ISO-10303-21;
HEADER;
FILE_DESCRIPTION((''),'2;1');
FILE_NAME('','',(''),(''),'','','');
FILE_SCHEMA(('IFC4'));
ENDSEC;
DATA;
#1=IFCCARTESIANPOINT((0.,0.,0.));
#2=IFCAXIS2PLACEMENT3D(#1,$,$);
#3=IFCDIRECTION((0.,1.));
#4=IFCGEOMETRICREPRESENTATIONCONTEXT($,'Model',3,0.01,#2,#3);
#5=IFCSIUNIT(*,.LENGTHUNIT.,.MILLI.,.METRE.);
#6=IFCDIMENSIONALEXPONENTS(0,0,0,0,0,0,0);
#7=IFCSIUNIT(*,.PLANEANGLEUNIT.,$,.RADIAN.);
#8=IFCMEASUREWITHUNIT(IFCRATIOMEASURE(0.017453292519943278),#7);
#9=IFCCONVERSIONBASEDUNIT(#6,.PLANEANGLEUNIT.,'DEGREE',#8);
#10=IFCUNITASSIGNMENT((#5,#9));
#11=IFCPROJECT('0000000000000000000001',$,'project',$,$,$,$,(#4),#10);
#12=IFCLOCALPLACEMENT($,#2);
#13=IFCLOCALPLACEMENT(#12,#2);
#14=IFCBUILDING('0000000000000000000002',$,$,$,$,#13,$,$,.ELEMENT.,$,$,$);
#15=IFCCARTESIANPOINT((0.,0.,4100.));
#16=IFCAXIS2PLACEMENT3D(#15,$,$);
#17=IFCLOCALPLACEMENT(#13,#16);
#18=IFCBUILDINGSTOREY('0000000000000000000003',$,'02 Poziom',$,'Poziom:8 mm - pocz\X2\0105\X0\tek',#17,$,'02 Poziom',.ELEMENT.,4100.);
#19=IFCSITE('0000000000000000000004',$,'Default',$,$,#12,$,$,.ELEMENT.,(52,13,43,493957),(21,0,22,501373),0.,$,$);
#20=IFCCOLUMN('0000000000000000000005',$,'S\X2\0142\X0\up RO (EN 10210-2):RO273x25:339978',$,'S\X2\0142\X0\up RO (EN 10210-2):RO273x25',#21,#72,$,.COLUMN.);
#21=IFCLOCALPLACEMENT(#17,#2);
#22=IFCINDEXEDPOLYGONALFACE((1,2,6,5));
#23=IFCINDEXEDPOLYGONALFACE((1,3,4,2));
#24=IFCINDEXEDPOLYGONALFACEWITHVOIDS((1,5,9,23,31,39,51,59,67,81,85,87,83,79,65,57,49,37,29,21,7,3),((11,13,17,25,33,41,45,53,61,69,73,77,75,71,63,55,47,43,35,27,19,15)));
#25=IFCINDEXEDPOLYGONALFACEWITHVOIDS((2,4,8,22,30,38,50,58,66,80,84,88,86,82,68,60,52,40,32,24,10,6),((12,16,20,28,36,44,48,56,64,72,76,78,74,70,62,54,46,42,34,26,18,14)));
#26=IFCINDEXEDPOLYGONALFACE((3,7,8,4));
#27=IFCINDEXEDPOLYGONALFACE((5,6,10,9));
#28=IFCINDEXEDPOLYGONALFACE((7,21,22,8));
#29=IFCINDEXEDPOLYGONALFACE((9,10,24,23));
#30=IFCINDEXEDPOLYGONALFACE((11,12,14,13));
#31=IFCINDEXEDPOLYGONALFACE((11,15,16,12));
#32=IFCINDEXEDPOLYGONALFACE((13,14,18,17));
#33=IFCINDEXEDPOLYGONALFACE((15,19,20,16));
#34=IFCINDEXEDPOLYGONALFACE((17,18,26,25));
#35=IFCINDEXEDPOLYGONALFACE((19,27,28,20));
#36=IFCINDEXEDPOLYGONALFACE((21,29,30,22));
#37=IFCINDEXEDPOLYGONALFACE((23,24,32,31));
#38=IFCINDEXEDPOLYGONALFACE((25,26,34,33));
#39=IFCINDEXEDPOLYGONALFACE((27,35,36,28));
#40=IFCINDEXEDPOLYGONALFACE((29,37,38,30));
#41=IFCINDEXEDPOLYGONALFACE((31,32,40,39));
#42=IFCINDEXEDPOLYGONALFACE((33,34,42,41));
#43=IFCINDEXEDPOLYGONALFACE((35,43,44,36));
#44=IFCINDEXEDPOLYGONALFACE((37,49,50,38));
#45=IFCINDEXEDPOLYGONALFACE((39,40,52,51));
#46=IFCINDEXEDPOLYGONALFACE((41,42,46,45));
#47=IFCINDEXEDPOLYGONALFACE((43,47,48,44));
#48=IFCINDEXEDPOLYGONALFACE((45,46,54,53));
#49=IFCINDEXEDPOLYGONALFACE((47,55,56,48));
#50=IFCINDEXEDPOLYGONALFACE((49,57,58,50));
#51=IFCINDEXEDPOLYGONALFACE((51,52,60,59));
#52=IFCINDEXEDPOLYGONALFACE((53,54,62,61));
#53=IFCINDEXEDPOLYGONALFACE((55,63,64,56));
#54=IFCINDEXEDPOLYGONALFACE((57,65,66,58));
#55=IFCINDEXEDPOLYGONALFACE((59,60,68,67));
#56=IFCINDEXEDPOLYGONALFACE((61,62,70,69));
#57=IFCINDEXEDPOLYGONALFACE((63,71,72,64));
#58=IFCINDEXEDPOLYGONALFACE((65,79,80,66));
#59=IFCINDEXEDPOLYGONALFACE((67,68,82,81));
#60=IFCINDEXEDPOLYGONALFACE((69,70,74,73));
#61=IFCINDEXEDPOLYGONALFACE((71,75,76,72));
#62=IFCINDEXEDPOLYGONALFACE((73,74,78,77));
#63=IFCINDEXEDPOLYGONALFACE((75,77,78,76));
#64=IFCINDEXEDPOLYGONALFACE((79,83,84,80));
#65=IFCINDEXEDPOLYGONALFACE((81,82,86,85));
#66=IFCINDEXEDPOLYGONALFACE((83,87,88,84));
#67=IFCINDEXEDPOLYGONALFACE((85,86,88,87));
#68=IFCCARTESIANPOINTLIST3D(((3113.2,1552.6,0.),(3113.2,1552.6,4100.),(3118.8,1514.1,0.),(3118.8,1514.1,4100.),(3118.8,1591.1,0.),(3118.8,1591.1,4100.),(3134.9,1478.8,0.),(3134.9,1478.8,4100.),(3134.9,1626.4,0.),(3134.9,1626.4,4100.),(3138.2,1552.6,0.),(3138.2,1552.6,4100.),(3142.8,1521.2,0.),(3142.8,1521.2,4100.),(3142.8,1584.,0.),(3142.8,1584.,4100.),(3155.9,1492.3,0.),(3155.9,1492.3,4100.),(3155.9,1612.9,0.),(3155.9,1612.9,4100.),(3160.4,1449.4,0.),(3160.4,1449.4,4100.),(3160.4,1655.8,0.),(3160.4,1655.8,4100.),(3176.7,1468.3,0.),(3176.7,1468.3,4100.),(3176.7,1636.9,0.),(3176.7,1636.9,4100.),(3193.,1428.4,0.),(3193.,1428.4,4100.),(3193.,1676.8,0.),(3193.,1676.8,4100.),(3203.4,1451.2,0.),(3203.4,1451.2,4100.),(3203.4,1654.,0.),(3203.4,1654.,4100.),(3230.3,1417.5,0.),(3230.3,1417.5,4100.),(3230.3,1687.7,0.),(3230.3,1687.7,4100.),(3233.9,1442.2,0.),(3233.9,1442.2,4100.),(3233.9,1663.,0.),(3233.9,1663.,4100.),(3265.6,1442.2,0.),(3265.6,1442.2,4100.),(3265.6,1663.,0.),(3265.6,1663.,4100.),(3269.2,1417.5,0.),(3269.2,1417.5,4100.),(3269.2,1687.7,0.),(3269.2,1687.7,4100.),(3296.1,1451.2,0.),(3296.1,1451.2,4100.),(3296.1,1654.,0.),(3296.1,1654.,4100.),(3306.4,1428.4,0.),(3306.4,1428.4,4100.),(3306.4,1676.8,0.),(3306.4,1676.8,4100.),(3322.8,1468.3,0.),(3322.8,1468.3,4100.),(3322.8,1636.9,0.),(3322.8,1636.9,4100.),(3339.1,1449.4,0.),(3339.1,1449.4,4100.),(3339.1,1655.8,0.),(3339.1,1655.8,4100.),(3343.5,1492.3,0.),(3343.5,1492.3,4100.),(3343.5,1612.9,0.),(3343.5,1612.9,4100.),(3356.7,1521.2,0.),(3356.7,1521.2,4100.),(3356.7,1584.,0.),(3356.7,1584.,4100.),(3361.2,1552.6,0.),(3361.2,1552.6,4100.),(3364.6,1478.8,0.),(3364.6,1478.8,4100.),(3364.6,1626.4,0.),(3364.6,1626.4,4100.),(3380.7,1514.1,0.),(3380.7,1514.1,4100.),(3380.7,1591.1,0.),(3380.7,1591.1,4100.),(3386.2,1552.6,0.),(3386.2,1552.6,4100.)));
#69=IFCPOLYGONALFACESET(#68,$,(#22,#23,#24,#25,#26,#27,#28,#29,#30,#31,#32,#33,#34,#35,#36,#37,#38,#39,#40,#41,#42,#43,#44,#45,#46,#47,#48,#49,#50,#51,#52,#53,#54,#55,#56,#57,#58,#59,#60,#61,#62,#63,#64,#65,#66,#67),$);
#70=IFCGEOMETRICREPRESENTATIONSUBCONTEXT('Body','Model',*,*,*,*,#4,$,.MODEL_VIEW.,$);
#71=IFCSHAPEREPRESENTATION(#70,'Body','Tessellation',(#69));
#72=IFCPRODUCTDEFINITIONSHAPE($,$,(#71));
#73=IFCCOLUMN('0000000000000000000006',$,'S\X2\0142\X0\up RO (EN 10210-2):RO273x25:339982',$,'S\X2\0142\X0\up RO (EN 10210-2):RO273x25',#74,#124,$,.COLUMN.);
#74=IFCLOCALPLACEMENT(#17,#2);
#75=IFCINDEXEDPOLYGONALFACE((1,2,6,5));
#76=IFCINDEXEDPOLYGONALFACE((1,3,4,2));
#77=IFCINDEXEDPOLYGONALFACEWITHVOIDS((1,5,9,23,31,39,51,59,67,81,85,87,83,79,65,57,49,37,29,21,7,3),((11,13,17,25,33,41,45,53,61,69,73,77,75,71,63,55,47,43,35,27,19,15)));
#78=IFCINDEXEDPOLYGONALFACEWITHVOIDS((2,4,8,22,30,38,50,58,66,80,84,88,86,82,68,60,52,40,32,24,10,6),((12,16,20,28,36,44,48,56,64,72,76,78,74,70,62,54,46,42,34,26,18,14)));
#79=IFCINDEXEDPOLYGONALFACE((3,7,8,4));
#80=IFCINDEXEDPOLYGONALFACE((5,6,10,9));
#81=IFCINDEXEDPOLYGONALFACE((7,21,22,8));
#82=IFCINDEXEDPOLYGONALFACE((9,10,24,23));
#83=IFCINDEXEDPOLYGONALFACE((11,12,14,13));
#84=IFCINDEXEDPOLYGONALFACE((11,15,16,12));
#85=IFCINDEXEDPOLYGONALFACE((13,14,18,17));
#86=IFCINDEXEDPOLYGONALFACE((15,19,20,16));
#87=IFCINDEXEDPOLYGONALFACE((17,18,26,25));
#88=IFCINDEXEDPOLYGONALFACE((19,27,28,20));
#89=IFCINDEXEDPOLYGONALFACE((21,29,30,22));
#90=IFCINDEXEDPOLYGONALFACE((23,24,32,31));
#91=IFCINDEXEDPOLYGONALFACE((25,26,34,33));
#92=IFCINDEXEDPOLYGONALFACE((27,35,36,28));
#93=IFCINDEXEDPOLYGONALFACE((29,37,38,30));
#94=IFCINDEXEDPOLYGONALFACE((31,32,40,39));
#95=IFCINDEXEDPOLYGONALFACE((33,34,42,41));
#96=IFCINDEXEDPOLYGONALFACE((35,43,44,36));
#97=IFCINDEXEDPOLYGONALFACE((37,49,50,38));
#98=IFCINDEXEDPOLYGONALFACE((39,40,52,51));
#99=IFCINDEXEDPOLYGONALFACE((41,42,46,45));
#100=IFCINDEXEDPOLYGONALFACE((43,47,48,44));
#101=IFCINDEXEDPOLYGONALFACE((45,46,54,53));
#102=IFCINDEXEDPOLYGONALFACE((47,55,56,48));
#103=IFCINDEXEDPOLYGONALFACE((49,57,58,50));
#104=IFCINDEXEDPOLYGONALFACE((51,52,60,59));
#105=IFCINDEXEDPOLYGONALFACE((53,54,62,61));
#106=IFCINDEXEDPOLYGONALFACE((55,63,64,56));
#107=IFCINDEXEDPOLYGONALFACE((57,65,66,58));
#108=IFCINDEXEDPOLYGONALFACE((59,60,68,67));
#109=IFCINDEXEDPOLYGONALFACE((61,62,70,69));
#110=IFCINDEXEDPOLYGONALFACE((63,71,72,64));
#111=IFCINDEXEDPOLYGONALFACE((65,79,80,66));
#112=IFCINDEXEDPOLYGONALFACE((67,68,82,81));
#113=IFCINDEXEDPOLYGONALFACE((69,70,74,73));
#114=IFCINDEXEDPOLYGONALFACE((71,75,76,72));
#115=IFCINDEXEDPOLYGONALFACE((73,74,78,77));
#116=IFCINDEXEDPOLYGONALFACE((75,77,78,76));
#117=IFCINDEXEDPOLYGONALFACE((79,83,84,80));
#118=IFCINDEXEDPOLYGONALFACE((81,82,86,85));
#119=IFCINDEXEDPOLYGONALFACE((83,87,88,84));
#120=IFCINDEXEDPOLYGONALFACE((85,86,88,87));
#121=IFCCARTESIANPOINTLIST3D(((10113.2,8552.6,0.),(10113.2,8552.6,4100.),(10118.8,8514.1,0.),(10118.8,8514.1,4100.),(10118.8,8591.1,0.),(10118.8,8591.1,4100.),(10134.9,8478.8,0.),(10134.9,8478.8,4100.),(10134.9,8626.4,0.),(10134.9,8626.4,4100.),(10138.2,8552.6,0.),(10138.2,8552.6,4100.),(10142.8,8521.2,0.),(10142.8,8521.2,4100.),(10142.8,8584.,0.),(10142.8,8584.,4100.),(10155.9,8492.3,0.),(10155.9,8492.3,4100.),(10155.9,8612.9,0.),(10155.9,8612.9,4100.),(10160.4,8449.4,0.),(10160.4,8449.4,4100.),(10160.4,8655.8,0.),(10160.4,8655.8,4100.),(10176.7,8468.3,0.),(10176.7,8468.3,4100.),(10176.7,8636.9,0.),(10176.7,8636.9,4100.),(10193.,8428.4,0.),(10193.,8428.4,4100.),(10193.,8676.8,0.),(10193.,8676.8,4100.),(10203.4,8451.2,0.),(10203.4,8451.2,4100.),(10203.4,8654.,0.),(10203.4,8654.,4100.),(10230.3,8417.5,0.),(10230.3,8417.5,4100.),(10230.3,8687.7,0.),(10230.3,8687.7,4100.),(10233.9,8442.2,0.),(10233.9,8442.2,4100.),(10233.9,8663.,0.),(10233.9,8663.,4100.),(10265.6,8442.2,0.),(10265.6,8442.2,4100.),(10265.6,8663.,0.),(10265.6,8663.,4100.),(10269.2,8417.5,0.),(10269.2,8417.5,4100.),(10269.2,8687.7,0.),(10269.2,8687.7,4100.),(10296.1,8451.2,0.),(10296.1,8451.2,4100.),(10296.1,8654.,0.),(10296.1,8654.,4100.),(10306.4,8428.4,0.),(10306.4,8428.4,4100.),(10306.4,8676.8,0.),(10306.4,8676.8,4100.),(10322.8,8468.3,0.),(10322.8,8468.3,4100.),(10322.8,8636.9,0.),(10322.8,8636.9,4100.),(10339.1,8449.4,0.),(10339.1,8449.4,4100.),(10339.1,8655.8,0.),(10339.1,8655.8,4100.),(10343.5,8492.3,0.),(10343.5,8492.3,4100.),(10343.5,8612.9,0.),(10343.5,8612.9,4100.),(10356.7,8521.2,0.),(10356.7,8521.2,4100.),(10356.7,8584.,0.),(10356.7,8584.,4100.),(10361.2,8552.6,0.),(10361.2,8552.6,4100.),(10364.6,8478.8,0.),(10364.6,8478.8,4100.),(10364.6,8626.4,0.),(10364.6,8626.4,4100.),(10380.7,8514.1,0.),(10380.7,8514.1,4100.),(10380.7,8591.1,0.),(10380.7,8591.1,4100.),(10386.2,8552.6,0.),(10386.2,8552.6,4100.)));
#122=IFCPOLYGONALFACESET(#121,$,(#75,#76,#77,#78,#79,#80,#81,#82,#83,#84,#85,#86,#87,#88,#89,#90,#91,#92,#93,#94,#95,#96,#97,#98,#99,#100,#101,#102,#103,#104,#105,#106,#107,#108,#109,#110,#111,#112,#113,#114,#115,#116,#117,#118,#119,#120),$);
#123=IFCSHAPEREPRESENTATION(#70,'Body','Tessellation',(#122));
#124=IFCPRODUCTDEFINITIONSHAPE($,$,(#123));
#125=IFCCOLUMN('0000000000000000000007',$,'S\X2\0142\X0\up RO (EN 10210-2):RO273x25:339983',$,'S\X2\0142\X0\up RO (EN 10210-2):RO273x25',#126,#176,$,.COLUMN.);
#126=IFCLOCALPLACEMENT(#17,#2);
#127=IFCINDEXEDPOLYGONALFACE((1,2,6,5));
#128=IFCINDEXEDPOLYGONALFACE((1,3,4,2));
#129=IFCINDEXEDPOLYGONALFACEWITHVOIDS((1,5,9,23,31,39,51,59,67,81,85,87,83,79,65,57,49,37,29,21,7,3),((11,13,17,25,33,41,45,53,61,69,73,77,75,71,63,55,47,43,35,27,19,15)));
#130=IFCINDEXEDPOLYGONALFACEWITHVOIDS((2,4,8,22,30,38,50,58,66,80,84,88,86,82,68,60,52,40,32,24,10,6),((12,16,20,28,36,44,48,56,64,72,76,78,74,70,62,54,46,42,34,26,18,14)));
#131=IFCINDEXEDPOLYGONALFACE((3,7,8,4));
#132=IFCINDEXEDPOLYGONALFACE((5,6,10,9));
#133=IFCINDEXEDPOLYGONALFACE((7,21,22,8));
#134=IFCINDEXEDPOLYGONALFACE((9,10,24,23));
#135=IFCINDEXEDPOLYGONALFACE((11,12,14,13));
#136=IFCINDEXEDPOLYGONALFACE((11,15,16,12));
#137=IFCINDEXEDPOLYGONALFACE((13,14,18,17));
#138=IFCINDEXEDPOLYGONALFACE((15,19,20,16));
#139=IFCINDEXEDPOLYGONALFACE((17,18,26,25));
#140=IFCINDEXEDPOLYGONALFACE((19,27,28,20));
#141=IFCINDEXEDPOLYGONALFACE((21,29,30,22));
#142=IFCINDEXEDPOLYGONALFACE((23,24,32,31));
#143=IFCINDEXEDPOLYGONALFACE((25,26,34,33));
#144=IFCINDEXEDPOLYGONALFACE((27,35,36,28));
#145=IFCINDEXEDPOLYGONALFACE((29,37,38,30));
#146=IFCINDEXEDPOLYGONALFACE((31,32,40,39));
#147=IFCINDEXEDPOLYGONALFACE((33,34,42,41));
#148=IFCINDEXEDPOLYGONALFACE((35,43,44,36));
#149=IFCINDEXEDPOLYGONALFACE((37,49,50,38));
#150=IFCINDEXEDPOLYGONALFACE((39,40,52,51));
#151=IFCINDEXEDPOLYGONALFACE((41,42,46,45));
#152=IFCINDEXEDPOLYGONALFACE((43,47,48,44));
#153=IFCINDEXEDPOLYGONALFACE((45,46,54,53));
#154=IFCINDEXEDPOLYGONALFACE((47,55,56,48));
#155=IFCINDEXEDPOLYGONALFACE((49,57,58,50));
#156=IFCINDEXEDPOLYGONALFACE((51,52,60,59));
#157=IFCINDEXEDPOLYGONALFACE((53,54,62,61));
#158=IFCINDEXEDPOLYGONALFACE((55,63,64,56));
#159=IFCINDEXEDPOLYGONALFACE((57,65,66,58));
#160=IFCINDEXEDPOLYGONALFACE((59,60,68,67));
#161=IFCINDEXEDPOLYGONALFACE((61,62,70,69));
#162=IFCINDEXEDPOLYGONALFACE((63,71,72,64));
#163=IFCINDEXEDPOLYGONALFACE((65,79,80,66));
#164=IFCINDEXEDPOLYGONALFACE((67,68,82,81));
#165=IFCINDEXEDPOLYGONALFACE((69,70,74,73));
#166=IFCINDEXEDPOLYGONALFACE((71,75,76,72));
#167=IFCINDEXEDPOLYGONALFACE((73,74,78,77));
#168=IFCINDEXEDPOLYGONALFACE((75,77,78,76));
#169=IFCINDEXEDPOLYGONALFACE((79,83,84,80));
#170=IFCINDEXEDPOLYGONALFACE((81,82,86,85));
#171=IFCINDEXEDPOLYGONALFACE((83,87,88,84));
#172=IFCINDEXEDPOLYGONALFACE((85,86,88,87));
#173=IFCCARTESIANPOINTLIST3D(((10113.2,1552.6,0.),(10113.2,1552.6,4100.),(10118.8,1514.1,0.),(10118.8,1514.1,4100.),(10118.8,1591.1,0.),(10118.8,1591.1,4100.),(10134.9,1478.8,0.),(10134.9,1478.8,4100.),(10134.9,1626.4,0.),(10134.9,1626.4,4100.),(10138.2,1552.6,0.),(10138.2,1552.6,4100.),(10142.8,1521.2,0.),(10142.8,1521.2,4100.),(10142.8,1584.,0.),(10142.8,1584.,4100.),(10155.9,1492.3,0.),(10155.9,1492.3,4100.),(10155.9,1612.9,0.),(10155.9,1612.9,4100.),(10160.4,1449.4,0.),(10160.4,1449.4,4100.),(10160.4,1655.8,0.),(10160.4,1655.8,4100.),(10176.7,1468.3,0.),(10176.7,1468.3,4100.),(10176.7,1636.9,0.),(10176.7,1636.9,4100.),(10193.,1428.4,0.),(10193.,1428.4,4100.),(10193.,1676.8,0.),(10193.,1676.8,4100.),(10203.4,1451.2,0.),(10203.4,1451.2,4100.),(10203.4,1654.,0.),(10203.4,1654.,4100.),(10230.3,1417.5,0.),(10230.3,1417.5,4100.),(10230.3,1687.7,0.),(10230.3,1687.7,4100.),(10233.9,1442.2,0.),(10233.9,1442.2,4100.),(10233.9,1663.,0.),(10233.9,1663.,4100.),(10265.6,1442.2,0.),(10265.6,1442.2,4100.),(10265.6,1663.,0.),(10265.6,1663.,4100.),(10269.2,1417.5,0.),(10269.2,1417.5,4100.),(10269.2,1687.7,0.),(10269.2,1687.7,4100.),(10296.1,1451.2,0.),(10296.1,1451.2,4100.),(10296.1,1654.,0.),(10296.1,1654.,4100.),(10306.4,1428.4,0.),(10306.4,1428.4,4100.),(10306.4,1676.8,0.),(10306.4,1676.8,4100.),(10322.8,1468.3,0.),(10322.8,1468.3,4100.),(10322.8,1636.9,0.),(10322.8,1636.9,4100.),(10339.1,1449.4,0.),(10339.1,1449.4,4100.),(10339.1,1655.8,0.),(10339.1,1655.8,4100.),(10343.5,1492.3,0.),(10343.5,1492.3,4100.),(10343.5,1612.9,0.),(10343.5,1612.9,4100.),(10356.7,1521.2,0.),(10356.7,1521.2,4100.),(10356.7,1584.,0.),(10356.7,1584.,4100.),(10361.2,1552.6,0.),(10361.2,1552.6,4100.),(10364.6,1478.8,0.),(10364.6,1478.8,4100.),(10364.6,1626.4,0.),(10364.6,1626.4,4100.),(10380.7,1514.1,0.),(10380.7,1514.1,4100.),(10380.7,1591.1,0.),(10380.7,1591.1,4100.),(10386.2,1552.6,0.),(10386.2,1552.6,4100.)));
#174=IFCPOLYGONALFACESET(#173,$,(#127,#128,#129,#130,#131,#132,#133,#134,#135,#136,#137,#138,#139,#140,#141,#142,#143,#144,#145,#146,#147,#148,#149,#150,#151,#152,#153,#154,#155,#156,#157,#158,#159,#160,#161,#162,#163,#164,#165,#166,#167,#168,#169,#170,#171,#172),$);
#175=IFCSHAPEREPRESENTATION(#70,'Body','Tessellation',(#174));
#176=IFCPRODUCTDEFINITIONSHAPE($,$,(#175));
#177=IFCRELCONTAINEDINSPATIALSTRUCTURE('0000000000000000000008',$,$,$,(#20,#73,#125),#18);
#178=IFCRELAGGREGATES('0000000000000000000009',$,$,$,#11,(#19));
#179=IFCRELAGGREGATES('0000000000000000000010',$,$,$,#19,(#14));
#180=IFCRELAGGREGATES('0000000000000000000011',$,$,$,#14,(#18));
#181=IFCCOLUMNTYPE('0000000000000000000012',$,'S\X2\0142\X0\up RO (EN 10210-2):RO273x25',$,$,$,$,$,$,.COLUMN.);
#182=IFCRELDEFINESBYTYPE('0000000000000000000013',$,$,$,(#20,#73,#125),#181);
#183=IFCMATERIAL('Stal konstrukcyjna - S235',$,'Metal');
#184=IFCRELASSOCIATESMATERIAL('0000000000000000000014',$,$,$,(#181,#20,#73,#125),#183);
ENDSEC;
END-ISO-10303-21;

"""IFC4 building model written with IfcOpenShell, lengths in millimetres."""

from ifc_helpers import new_model, entity, si_unit, converted_unit, direction, frame, origin, place, context, subcontext, project, spatial, arc, indexed_curve, outline, extrude, source, transform, mapped, material, type_object, type_shapes, element, save


model = new_model("IFC4")

# Units and contexts
model_context = context("Model", 3, precision=0.01, world=origin(), true_north=direction((0.0, 1.0)))
body_context = subcontext(model_context, "Body", "Model", "MODEL_VIEW")
ifc_project = project(units=[si_unit("LENGTHUNIT", "METRE", prefix="MILLI"), converted_unit("PLANEANGLEUNIT", "DEGREE", entity("IfcRatioMeasure", 0.017453292519943278), si_unit("PLANEANGLEUNIT", "RADIAN"), dimensions=[0, 0, 0, 0, 0, 0, 0])], contexts=[model_context])

# Site, building, storey
site_placement = place(None, origin())
site = spatial("IfcSite", under=ifc_project, at=site_placement, Name="Default", CompositionType="ELEMENT", RefLatitude=(52, 13, 43, 493957), RefLongitude=(21, 0, 22, 501373), RefElevation=0.0)
building_placement = place(site_placement, origin())
building = spatial("IfcBuilding", under=site, at=building_placement, CompositionType="ELEMENT")
storey_placement = place(building_placement, frame((0.0, 0.0, 4100.0)))
storey = spatial("IfcBuildingStorey", under=building, at=storey_placement, Name="02 Poziom", ObjectType="Poziom:8 mm - początek", LongName="02 Poziom", CompositionType="ELEMENT", Elevation=4100.0)

# Columns
ifc_material_1 = material(Name="Stal konstrukcyjna - S235", Category="Metal")
column_type = type_object("IfcColumnType", Name="Słup RO (EN 10210-2):RO273x25", PredefinedType="COLUMN", material=ifc_material_1)
shared_shape_1 = source(origin(), body_context, "Body", "SweptSolid", [
    extrude(outline(indexed_curve([(-136.5, 0.0), (0.0, -136.5), (136.5, 0.0), (0.0, 136.5)], segments=[arc(1, 2, 3), arc(3, 4, 1)], self_intersect=False), holes=[indexed_curve([(-111.5, 0.0), (0.0, 111.5), (111.5, 0.0), (0.0, -111.5)], segments=[arc(1, 2, 3), arc(3, 4, 1)], self_intersect=False)]), frame((0.0, 0.0, 4100.0)), (0.0, 0.0, 1.0), 4100.0),
])
type_shapes(column_type, [shared_shape_1])
for number, where, name in (
    (1, (3249.7, 1552.6, -4100.0), "Słup RO (EN 10210-2):RO273x25:339978"),
    (2, (10249.7, 8552.6, -4100.0), "Słup RO (EN 10210-2):RO273x25:339982"),
    (3, (10249.7, 1552.6, -4100.0), "Słup RO (EN 10210-2):RO273x25:339983"),
):
    element("IfcColumn", number, at=place(storey_placement, frame(where)), inside=storey, type_object=column_type, material=ifc_material_1, Name=name, ObjectType="Słup RO (EN 10210-2):RO273x25", PredefinedType="COLUMN", context=body_context, shape_type="MappedRepresentation", body=[
        mapped(shared_shape_1, transform((0.0, 0.0, 0.0), scale=1.0)),
    ])

save(model, "model.ifc")
